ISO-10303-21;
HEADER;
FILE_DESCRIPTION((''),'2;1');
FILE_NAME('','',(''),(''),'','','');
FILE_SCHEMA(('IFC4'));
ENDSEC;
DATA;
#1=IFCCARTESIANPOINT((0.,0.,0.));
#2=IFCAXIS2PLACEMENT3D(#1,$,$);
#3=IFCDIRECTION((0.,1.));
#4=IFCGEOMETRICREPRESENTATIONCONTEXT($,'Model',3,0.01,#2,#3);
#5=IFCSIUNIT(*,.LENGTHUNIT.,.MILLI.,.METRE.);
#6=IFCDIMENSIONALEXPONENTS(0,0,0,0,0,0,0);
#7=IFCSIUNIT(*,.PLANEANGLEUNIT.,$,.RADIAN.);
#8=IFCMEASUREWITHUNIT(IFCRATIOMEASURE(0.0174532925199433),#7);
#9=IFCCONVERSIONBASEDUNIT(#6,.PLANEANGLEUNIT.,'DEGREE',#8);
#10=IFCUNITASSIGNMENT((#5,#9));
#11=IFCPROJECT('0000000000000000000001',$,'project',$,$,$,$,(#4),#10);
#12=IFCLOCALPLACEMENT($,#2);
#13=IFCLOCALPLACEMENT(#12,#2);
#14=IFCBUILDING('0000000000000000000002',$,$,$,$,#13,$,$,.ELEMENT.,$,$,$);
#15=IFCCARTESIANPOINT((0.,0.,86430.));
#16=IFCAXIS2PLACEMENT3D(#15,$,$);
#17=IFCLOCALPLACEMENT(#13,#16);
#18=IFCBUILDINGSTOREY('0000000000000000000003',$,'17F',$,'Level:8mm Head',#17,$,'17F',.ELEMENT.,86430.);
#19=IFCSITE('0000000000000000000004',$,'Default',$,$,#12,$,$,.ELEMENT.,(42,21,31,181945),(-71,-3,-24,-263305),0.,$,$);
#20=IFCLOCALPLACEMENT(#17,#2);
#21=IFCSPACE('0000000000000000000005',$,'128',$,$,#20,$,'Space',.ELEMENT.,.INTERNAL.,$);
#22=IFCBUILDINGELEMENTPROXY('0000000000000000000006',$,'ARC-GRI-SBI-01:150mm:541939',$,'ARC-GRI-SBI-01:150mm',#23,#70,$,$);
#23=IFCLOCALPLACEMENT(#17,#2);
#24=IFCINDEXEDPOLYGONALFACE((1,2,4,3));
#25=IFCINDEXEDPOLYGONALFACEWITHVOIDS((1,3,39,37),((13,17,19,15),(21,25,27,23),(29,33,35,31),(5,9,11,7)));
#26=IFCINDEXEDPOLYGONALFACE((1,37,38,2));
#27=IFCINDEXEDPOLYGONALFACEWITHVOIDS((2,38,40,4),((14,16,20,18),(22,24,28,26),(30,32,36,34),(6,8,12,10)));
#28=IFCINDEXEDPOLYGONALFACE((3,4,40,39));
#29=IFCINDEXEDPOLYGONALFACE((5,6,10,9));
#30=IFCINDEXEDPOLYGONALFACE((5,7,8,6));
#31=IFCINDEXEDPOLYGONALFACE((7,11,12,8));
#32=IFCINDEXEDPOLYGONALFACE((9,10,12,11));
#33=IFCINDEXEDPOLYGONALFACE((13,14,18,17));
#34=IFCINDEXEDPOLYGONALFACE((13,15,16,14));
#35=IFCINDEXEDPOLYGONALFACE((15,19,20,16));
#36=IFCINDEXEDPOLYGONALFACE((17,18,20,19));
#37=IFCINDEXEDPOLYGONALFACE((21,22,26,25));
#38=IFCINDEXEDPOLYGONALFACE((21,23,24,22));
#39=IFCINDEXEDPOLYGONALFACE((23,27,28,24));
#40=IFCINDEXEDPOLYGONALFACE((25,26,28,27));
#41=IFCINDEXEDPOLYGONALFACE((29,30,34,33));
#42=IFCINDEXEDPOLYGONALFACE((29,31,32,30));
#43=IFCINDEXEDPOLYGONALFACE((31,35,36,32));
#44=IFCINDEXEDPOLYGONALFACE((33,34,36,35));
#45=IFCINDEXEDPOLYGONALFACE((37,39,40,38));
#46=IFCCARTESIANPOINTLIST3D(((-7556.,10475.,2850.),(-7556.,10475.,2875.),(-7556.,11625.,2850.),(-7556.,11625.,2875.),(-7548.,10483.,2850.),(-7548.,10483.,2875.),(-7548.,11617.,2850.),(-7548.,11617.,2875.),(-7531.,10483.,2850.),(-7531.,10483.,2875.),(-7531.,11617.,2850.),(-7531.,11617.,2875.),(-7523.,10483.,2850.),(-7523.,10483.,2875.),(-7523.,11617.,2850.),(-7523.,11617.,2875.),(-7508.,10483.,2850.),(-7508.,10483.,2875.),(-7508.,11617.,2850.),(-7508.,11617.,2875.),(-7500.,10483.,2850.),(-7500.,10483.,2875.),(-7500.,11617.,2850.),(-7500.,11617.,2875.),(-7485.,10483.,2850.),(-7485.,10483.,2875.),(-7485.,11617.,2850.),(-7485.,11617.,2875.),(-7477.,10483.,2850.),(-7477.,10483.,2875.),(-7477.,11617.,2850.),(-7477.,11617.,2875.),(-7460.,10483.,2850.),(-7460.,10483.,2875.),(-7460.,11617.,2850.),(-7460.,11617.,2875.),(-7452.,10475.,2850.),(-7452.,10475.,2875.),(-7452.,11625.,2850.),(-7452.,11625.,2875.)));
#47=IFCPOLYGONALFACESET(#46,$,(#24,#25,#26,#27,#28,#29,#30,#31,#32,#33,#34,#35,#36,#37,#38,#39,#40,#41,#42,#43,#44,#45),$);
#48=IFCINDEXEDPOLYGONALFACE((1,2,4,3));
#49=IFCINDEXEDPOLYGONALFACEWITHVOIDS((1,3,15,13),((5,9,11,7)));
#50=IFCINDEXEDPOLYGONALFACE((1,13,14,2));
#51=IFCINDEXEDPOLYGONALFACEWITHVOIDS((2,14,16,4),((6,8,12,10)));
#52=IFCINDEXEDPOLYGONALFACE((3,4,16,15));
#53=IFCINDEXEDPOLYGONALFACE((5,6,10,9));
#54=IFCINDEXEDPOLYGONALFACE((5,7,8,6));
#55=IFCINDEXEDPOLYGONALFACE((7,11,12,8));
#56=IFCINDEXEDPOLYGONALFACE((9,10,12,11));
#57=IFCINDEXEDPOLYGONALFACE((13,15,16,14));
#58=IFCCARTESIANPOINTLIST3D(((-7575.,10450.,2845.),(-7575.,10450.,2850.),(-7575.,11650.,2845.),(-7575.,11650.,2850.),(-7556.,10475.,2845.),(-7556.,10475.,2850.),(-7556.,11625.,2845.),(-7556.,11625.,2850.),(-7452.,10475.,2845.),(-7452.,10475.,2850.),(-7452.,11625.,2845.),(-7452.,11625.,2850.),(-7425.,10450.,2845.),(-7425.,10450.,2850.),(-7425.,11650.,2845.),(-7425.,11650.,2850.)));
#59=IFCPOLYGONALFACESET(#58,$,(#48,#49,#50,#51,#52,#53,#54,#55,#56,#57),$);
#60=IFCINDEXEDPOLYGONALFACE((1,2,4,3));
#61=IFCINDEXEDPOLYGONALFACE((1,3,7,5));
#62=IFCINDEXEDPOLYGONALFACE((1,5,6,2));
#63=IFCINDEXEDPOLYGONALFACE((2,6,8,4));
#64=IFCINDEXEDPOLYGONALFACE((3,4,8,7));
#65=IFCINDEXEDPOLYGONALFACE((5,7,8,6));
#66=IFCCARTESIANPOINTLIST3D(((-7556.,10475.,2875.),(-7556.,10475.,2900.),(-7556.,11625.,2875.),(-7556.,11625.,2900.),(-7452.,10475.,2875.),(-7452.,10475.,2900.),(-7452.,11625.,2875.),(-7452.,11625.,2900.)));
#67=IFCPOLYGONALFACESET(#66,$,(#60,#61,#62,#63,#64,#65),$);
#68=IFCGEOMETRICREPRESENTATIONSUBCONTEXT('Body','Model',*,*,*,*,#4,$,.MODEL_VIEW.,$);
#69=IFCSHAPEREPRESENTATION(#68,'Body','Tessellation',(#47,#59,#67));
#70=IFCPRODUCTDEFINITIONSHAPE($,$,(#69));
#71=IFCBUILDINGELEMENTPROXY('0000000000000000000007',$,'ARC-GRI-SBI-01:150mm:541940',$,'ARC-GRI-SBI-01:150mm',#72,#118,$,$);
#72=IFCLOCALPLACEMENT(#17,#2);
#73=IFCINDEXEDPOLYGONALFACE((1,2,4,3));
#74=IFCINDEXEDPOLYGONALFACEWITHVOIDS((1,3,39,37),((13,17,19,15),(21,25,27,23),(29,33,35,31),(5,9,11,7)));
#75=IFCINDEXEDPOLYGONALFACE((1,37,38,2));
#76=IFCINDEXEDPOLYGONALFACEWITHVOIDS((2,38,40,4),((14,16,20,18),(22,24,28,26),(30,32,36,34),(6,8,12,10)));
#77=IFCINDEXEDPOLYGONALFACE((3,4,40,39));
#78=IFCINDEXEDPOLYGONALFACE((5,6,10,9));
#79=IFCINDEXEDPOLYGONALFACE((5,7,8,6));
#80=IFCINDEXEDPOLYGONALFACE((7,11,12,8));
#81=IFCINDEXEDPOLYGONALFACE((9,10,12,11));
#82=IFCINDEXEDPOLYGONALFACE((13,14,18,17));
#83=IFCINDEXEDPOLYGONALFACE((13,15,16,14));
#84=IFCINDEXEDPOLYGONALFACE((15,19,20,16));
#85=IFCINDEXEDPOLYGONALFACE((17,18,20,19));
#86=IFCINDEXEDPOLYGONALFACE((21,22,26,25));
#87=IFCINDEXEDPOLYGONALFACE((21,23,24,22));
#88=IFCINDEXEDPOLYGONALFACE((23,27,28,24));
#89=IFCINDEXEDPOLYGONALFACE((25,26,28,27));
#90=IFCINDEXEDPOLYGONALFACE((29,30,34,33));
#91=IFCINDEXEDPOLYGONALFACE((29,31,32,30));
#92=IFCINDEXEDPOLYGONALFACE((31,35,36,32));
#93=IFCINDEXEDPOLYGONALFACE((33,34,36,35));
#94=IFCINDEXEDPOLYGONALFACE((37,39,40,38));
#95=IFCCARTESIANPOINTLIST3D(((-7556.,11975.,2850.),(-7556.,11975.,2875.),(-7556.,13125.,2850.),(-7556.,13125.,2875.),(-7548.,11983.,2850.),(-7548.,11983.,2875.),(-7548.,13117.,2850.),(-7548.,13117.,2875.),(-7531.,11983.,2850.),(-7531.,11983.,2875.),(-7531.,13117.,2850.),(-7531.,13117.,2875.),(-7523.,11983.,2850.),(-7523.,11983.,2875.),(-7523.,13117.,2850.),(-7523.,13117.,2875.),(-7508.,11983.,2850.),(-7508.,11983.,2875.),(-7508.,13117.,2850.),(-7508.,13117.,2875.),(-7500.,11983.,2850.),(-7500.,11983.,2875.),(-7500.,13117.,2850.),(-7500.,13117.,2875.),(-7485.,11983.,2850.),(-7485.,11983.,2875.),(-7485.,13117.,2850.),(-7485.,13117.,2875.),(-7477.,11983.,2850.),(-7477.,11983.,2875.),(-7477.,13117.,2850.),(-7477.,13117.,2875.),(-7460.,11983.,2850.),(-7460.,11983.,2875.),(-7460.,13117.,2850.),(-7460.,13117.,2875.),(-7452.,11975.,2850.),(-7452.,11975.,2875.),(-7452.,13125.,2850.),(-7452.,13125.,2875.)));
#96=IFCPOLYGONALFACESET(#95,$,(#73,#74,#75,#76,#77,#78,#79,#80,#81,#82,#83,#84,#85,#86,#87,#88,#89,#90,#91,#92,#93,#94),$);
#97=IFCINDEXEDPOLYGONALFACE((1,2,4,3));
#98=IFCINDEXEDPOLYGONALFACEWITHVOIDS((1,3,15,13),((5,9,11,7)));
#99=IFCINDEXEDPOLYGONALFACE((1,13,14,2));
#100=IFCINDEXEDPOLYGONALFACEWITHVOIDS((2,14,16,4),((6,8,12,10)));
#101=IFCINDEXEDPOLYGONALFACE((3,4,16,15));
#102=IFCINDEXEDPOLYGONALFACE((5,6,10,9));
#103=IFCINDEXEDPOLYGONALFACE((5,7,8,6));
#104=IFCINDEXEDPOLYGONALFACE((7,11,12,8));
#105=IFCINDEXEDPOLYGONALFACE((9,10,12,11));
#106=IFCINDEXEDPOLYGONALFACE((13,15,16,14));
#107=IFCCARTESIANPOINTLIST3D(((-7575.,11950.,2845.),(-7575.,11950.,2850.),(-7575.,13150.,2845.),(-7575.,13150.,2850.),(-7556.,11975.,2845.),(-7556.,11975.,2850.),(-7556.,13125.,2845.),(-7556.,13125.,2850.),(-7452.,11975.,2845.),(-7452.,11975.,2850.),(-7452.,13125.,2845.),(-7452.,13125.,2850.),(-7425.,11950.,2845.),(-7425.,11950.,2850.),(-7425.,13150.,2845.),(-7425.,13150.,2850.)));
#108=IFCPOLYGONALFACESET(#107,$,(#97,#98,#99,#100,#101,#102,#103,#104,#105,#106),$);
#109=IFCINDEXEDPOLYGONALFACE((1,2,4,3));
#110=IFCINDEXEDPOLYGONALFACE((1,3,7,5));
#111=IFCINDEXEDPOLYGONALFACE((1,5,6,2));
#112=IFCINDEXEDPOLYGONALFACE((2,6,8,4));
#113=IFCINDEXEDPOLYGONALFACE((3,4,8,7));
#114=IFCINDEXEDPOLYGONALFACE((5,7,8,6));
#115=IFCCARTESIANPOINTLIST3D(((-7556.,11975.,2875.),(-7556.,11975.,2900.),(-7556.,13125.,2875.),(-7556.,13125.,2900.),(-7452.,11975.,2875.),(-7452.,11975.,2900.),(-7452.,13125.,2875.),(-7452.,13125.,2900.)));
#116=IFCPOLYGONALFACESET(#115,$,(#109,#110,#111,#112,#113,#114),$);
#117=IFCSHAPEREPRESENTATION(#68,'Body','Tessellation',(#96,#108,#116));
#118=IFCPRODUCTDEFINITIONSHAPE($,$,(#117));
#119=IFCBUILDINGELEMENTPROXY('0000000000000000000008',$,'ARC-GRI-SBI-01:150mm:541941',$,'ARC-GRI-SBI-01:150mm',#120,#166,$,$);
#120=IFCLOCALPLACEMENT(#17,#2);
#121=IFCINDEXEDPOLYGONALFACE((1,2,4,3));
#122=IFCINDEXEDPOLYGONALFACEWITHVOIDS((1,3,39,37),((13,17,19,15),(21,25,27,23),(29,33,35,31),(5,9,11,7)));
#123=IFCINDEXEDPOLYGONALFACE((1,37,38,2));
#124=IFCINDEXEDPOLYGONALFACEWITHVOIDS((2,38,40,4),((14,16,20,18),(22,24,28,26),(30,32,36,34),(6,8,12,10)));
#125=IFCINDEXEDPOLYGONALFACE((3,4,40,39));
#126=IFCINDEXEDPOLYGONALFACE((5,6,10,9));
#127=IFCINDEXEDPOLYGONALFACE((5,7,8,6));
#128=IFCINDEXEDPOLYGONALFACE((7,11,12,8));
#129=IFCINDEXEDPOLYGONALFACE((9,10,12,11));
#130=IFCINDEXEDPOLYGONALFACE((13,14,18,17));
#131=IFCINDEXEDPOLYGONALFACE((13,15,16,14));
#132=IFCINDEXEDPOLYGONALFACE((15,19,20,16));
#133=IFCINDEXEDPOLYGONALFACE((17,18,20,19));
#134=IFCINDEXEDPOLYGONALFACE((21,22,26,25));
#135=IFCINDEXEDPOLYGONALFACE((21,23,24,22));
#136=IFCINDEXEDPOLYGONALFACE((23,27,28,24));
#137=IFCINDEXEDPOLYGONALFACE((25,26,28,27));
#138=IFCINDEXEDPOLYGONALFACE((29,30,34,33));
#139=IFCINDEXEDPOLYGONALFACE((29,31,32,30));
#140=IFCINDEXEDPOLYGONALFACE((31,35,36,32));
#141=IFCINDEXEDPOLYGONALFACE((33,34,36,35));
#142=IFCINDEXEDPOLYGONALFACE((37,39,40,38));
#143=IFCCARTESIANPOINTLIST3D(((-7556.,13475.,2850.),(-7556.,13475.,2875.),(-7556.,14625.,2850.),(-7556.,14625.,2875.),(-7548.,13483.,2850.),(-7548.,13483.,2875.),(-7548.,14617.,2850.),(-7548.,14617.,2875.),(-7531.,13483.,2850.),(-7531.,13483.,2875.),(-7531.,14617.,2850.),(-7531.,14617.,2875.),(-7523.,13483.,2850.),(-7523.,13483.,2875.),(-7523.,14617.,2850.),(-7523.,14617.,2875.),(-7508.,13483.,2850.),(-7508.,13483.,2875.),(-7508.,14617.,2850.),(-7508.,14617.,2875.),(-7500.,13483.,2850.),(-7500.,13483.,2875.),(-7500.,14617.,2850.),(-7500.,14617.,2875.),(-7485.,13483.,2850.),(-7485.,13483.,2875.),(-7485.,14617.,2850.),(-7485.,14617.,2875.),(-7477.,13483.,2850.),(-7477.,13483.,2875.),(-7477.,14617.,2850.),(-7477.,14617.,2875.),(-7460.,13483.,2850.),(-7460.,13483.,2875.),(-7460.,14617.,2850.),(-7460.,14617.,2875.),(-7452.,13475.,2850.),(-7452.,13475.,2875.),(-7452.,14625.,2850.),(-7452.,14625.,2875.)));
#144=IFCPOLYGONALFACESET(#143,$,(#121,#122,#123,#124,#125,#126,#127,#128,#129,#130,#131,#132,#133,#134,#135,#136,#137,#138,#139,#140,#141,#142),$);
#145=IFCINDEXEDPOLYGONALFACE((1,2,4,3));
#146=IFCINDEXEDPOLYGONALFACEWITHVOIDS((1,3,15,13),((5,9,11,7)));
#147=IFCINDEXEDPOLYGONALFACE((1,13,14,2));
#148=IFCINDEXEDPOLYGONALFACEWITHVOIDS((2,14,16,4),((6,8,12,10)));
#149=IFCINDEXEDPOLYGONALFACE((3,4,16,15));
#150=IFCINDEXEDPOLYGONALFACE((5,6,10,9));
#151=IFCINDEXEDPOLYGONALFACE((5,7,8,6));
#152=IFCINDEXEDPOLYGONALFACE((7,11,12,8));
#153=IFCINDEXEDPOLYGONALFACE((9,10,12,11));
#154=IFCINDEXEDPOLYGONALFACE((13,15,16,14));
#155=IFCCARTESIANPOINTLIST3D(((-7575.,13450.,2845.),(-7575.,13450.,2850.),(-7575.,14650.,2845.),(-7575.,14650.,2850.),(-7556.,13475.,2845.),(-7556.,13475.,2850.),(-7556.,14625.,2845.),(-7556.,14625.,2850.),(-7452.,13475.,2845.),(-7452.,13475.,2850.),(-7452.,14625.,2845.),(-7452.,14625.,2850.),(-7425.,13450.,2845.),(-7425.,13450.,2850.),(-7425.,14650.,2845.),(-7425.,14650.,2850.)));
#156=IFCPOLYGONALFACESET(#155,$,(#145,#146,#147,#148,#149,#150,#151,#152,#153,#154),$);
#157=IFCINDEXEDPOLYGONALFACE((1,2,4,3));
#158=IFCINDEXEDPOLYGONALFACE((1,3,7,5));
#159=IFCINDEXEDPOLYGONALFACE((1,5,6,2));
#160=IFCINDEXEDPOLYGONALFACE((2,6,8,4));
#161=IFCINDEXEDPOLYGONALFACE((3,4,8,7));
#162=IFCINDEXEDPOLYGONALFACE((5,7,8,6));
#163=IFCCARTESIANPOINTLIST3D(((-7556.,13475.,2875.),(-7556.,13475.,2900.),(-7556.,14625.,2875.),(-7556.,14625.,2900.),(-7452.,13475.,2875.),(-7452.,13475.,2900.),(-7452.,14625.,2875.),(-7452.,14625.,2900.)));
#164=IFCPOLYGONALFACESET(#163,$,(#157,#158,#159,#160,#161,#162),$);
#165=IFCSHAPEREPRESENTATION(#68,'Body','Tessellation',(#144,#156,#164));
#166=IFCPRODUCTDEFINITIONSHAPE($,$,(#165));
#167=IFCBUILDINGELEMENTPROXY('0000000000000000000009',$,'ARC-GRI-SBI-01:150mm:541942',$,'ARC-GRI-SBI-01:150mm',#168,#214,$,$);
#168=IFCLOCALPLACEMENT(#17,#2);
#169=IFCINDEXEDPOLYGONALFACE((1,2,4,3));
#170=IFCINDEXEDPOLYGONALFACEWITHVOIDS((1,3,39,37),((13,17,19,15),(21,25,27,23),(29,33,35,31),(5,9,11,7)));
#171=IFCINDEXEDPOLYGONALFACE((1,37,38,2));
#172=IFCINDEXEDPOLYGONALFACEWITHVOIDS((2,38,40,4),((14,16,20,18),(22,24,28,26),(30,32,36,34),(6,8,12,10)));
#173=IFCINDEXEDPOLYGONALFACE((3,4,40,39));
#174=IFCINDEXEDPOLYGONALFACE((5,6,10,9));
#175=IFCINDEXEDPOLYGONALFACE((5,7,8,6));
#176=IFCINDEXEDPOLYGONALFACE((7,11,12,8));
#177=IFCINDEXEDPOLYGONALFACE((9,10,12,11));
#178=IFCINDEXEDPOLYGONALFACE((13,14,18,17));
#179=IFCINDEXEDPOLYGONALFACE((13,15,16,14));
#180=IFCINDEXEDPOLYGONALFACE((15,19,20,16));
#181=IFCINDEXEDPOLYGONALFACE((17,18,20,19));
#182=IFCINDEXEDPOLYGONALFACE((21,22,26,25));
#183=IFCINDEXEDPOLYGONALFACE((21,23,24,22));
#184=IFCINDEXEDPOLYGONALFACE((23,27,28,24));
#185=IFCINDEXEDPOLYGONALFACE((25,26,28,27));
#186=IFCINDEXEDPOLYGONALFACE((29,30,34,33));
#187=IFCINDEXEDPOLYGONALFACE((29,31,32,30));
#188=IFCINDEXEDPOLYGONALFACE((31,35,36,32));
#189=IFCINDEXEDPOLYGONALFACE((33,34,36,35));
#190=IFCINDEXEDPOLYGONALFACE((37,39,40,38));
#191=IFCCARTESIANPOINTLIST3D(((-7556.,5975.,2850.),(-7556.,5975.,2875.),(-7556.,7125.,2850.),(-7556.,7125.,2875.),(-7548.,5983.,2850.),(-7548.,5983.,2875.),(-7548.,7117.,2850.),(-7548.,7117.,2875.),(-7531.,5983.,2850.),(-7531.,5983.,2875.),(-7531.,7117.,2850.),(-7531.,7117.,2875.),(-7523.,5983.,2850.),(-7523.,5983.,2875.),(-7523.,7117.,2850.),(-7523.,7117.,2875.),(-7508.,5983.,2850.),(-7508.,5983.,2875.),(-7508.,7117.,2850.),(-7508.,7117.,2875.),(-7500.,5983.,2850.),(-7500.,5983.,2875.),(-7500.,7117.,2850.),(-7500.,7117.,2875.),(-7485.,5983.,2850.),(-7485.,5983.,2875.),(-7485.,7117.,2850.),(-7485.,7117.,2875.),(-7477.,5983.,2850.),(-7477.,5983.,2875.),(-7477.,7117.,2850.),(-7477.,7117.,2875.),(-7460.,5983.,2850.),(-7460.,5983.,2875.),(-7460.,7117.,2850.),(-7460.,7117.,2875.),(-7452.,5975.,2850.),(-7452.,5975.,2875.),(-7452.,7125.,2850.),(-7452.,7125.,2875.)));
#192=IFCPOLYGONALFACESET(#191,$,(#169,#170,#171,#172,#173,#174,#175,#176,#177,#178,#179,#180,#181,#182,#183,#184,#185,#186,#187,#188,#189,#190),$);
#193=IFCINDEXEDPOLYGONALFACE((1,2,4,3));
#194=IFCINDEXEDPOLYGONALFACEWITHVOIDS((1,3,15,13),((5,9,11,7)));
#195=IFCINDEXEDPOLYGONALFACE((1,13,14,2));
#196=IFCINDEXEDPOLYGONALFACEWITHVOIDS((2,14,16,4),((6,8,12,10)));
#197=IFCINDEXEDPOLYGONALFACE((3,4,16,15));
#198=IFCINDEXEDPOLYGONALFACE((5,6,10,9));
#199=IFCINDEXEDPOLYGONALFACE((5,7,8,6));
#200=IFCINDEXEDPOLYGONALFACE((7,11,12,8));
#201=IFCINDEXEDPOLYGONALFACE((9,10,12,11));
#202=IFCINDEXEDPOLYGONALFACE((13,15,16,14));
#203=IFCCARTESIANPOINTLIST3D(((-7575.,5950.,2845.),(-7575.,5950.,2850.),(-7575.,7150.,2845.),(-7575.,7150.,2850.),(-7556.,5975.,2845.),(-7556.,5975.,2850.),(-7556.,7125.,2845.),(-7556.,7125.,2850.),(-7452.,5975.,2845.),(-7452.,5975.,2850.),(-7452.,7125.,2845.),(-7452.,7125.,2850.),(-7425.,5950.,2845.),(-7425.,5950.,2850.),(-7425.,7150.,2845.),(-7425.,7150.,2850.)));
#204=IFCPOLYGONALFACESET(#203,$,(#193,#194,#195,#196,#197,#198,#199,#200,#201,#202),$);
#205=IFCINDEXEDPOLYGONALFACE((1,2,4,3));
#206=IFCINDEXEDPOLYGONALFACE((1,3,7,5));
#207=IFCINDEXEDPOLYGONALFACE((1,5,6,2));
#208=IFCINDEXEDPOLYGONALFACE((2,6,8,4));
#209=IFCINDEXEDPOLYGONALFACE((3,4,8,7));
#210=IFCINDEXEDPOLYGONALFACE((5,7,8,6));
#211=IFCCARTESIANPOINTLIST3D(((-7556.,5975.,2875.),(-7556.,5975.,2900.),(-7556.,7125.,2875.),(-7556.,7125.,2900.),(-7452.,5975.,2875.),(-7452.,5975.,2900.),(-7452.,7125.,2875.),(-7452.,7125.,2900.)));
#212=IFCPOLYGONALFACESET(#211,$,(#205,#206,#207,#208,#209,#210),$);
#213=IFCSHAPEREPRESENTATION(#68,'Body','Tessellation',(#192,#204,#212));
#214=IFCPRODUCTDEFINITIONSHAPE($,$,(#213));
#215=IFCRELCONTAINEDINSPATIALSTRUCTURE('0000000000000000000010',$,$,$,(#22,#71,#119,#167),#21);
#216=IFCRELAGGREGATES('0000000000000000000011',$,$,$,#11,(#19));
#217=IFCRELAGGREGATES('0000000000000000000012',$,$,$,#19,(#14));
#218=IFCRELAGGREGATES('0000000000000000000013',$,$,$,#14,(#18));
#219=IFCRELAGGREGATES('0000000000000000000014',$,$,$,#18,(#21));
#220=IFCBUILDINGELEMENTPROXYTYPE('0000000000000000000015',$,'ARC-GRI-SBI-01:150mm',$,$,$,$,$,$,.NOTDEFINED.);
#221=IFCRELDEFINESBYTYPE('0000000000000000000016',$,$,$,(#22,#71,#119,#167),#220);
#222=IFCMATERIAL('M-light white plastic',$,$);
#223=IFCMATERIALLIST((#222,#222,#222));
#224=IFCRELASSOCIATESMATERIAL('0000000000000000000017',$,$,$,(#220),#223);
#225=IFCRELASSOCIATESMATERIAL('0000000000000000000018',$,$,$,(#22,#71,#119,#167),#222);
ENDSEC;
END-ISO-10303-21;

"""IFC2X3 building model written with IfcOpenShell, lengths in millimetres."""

from ifc_helpers import new_model, entity, si_unit, converted_unit, direction, frame, origin, origin_2d_with_axis, place, context, subcontext, project, spatial, polyline, rectangle, outline, extrude, source, transform, mapped, material, material_list, type_object, type_shapes, element, save


model = new_model("IFC2X3")

# Units and contexts
model_context = context("Model", 3, precision=0.01, world=origin(), true_north=direction((0.0, 1.0)))
body_context = subcontext(model_context, "Body", "Model", "MODEL_VIEW")
ifc_project = project(units=[si_unit("LENGTHUNIT", "METRE", prefix="MILLI"), converted_unit("PLANEANGLEUNIT", "DEGREE", entity("IfcRatioMeasure", 0.0174532925199433), si_unit("PLANEANGLEUNIT", "RADIAN"), dimensions=[0, 0, 0, 0, 0, 0, 0])], contexts=[model_context])

# Site, building, storey, space
site_placement = place(None, origin())
site = spatial("IfcSite", under=ifc_project, at=site_placement, Name="Default", CompositionType="ELEMENT", RefLatitude=(42, 21, 31, 181945), RefLongitude=(-71, -3, -24, -263305), RefElevation=0.0)
building_placement = place(site_placement, origin())
building = spatial("IfcBuilding", under=site, at=building_placement, CompositionType="ELEMENT")
storey_placement = place(building_placement, frame((0.0, 0.0, 86430.0)))
storey = spatial("IfcBuildingStorey", under=building, at=storey_placement, Name="17F", ObjectType="Level:8mm Head", LongName="17F", CompositionType="ELEMENT", Elevation=86430.0)
space_placement = place(storey_placement, origin())
space = spatial("IfcSpace", under=storey, at=space_placement, Name="128", LongName="Space", CompositionType="ELEMENT", InteriorOrExteriorSpace="INTERNAL")

# Shared definitions
ifc_material_1 = material(Name="M-light white plastic")

# Building element proxies
ifc_material_list_1 = material_list([ifc_material_1, ifc_material_1, ifc_material_1])
building_element_proxy_type = type_object("IfcBuildingElementProxyType", Name="ARC-GRI-SBI-01:150mm", PredefinedType="NOTDEFINED", material=ifc_material_list_1)
shared_shape_1 = source(origin(), body_context, "Body", "SweptSolid", [
    extrude(outline(polyline([(-575.0, -52.0), (575.0, -52.0), (575.0, 52.0), (-575.0, 52.0), (-575.0, -52.0)]), holes=[polyline([(-567.0, -44.0), (-567.0, -27.0), (567.0, -27.0), (567.0, -44.0), (-567.0, -44.0)]), polyline([(567.0, -4.0), (567.0, -19.0), (-567.0, -19.0), (-567.0, -4.0), (567.0, -4.0)]), polyline([(-567.0, 44.0), (567.0, 44.0), (567.0, 27.0), (-567.0, 27.0), (-567.0, 44.0)]), polyline([(567.0, 4.0), (-567.0, 4.0), (-567.0, 19.0), (567.0, 19.0), (567.0, 4.0)])]), frame((425.0, 4.0, 4000.0), z_axis=(0.0, 0.0, 1.0), x_axis=(-1.0, 0.0, 0.0)), (0.0, 0.0, 1.0), 25.0),
    extrude(outline(polyline([(-600.0, -75.0), (600.0, -75.0), (600.0, 75.0), (-600.0, 75.0), (-600.0, -75.0)]), holes=[polyline([(-575.0, -56.0), (-575.0, 48.0), (575.0, 48.0), (575.0, -56.0), (-575.0, -56.0)])]), frame((425.0, 0.0, 3995.0), z_axis=(0.0, 0.0, 1.0), x_axis=(-1.0, 0.0, 0.0)), (0.0, 0.0, 1.0), 5.0),
    extrude(rectangle(XDim=1150.0, YDim=104.0, at=origin_2d_with_axis()), frame((425.0, 4.0, 4025.0), z_axis=(0.0, 0.0, 1.0), x_axis=(-1.0, 0.0, 0.0)), (0.0, 0.0, 1.0), 25.0),
])
type_shapes(building_element_proxy_type, [shared_shape_1])
for number, where, z_axis, x_axis, name in (
    (1, (-7500.0, 10625.0, -1150.0), (0.0, 0.0, 1.0), (0.0, 1.0, 0.0), "ARC-GRI-SBI-01:150mm:541939"),
    (2, (-7500.0, 12125.0, -1150.0), (0.0, 0.0, 1.0), (0.0, 1.0, 0.0), "ARC-GRI-SBI-01:150mm:541940"),
    (3, (-7500.0, 13625.0, -1150.0), (0.0, 0.0, 1.0), (0.0, 1.0, 0.0), "ARC-GRI-SBI-01:150mm:541941"),
    (4, (-7500.0, 6125.0, -1150.0), (0.0, 0.0, 1.0), (0.0, 1.0, 0.0), "ARC-GRI-SBI-01:150mm:541942"),
):
    element("IfcBuildingElementProxy", number, at=place(space_placement, frame(where, z_axis=z_axis, x_axis=x_axis)), inside=space, type_object=building_element_proxy_type, material=ifc_material_1, Name=name, ObjectType="ARC-GRI-SBI-01:150mm", context=body_context, shape_type="MappedRepresentation", body=[
        mapped(shared_shape_1, transform((0.0, 0.0, 0.0), scale=1.0)),
    ])

save(model, "model.ifc")
